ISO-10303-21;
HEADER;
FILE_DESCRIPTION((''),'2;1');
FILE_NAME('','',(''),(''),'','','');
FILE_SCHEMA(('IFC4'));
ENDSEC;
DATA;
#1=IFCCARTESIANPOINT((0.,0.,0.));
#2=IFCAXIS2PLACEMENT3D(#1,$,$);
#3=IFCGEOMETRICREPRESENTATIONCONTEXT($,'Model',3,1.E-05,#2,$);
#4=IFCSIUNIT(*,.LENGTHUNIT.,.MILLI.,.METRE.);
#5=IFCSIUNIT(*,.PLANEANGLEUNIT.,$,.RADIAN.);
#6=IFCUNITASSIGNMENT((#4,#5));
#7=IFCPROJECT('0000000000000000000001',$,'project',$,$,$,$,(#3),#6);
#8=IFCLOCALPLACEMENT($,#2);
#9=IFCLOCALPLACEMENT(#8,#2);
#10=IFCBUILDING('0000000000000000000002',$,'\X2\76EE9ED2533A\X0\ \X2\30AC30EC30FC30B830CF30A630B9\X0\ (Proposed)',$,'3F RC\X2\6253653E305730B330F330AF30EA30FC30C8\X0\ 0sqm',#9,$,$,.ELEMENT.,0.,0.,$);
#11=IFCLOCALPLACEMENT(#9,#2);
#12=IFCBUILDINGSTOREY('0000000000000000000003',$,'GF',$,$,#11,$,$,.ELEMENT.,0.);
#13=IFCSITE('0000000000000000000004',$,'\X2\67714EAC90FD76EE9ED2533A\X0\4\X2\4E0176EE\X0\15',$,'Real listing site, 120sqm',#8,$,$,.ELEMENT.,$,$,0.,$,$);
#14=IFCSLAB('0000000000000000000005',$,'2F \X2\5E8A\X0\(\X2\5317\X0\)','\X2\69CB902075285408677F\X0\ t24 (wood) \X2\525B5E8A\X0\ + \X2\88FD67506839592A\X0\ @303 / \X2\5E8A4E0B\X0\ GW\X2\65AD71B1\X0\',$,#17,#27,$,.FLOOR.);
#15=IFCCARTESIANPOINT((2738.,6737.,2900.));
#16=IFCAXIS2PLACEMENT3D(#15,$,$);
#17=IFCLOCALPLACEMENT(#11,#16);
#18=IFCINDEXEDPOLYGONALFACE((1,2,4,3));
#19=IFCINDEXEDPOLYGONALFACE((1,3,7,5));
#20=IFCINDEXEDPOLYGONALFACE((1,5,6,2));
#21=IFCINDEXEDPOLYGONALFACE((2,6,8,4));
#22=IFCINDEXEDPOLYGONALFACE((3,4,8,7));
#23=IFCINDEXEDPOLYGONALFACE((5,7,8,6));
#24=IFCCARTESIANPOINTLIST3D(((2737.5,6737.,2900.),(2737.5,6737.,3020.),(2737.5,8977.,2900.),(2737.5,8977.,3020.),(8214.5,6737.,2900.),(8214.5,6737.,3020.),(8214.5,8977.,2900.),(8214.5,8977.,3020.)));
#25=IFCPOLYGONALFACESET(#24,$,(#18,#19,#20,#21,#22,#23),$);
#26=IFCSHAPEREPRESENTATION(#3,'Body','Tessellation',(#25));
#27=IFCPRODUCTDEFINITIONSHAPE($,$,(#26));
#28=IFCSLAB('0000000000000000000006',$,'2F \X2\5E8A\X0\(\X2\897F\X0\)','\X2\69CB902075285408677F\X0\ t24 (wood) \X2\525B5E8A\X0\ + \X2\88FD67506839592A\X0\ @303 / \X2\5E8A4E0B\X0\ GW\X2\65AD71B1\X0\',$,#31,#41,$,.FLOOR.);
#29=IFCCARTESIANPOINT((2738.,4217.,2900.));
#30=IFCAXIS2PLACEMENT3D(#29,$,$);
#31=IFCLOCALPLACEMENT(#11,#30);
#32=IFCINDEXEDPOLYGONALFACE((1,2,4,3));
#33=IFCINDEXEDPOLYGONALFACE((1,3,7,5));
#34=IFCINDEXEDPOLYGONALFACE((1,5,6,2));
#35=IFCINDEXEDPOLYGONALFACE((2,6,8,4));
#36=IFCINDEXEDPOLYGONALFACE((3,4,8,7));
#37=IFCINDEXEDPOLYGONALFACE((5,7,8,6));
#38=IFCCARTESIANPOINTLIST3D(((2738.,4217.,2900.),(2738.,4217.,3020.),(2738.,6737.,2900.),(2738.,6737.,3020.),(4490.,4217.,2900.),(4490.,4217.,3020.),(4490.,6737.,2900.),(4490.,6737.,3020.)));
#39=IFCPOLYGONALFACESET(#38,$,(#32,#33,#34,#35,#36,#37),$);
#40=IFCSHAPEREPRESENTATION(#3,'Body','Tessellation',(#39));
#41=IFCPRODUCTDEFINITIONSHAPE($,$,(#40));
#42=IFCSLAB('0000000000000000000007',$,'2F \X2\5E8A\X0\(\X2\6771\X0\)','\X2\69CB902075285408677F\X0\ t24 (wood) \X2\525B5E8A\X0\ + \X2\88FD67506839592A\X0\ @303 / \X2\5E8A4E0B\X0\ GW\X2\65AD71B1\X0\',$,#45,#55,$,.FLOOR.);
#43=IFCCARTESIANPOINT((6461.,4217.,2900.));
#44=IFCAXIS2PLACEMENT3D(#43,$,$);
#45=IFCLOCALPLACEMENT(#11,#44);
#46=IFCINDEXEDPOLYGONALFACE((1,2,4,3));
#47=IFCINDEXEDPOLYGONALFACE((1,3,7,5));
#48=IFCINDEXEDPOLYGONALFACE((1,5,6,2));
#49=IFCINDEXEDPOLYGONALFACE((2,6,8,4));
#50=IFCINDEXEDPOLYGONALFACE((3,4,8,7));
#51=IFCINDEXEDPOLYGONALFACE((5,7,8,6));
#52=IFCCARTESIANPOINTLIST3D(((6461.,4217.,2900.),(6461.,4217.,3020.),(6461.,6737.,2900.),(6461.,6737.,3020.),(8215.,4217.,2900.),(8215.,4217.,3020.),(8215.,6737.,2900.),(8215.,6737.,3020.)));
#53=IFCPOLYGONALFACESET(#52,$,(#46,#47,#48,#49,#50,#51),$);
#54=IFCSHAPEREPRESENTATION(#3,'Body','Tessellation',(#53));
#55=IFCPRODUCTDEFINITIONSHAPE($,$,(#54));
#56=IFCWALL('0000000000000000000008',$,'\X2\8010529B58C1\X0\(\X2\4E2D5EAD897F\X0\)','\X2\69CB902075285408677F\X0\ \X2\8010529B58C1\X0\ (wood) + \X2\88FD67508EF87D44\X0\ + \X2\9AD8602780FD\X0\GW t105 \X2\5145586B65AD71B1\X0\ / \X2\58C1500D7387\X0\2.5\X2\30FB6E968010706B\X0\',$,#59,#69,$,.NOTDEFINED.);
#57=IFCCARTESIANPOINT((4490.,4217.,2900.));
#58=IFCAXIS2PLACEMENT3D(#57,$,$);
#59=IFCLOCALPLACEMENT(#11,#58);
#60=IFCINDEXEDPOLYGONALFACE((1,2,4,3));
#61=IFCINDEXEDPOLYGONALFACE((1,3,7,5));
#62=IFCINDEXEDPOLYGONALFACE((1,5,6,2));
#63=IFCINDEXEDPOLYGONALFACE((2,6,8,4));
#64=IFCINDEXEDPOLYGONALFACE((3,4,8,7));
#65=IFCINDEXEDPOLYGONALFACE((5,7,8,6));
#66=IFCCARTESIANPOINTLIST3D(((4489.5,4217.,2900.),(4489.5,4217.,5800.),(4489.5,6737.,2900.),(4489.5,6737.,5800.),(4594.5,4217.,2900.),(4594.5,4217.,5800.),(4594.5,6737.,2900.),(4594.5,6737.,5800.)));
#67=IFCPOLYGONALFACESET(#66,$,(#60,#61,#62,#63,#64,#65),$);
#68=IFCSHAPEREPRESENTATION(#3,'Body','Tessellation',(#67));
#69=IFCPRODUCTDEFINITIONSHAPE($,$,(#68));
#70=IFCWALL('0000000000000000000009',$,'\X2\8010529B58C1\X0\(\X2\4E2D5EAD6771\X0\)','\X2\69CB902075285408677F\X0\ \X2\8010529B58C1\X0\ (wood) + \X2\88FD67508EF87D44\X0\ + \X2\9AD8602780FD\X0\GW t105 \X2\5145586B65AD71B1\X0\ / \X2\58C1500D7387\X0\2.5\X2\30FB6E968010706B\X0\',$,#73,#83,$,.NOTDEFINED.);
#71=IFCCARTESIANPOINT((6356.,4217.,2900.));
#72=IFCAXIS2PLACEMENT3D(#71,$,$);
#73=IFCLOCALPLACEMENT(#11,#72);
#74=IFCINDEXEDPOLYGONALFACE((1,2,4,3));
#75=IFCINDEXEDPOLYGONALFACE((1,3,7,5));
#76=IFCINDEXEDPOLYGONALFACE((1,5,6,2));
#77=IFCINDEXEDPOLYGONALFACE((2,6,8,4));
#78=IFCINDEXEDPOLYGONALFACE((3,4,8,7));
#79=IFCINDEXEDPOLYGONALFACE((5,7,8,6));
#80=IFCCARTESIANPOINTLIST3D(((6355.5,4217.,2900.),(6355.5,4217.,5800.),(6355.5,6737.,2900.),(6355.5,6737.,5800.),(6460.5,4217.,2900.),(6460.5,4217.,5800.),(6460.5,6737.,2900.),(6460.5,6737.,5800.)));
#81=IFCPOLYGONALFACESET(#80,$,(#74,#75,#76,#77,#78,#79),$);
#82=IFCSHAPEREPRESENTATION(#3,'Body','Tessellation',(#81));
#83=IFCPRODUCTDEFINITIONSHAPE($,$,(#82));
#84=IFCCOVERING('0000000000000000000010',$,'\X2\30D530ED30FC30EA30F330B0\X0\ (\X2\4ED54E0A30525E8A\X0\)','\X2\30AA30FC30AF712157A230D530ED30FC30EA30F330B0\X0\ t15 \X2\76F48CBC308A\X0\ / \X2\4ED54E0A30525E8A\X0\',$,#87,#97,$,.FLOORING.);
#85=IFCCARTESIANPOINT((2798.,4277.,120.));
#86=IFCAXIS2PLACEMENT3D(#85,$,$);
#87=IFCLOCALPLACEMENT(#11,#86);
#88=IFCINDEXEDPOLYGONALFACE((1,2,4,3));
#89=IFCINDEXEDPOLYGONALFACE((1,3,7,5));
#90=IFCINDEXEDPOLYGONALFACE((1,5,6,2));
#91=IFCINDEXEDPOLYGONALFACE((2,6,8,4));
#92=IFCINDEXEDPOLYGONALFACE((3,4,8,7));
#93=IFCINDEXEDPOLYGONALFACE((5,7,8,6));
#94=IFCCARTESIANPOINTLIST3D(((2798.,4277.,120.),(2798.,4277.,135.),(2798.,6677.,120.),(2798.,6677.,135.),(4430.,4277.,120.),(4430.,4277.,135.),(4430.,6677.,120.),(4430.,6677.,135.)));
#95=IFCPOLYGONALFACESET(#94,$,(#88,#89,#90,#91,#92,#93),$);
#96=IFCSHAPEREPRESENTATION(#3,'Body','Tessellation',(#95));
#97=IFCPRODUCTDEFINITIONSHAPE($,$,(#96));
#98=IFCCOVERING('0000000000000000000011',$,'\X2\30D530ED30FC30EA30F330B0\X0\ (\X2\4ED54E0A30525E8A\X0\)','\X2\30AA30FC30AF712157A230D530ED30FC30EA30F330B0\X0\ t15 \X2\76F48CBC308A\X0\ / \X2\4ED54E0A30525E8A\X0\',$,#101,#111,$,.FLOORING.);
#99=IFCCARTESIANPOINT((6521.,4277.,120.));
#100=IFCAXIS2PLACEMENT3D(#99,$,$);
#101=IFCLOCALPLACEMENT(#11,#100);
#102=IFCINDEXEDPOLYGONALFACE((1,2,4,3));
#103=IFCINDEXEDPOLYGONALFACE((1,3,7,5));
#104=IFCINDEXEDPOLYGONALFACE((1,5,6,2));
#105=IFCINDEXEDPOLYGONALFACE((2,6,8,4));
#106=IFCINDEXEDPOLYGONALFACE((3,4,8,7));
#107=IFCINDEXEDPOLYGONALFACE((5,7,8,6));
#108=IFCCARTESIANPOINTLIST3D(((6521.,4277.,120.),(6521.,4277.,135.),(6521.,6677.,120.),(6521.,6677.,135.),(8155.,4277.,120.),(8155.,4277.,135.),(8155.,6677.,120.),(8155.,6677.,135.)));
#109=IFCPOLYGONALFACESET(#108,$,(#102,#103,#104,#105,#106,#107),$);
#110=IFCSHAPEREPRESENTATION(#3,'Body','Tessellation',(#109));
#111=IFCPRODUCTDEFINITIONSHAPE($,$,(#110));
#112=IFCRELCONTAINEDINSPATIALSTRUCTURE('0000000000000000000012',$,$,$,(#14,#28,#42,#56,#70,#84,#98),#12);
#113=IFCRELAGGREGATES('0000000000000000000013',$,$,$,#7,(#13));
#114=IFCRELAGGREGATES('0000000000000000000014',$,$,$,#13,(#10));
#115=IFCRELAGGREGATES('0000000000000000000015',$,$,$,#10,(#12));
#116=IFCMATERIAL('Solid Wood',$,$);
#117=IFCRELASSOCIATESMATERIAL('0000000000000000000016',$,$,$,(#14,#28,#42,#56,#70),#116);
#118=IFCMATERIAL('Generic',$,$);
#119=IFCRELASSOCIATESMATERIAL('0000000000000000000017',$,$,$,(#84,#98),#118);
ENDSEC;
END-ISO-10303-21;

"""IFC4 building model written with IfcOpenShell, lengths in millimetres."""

from ifc_helpers import new_model, si_unit, frame, frame_2d, origin, place, context, project, spatial, rectangle, extrude, material, element, save


model = new_model("IFC4")

# Units and contexts
model_context = context("Model", 3, precision=1e-05, world=origin())
ifc_project = project(units=[si_unit("LENGTHUNIT", "METRE", prefix="MILLI"), si_unit("PLANEANGLEUNIT", "RADIAN")], contexts=[model_context])

# Site, building, storey
site_placement = place(None, origin())
site = spatial("IfcSite", under=ifc_project, at=site_placement, Name="東京都目黒区4丁目15", ObjectType="Real listing site, 120sqm", CompositionType="ELEMENT", RefElevation=0.0)
building_placement = place(site_placement, origin())
building = spatial("IfcBuilding", under=site, at=building_placement, Name="目黒区 ガレージハウス (Proposed)", ObjectType="3F RC打放しコンクリート 0sqm", CompositionType="ELEMENT", ElevationOfRefHeight=0.0, ElevationOfTerrain=0.0)
storey_placement = place(building_placement, origin())
storey = spatial("IfcBuildingStorey", under=building, at=storey_placement, Name="GF", CompositionType="ELEMENT", Elevation=0.0)

# Slabs
ifc_material_1 = material(Name="Solid Wood")
slab_1_placement = place(storey_placement, frame((2738.0, 6737.0, 2900.0)))
element("IfcSlab", 1, at=slab_1_placement, inside=storey, material=ifc_material_1, Name="2F 床(北)", Description="構造用合板 t24 (wood) 剛床 + 製材根太 @303 / 床下 GW断熱", PredefinedType="FLOOR", context=model_context, shape_type="SweptSolid", body=[
    extrude(rectangle(XDim=5477.0, YDim=2240.0, at=frame_2d((2738.0, 1120.0))), frame((2738.0, 6737.0, 2900.0)), (0.0, 0.0, 1.0), 120.0),
])
slab_2_placement = place(storey_placement, frame((2738.0, 4217.0, 2900.0)))
element("IfcSlab", 2, at=slab_2_placement, inside=storey, material=ifc_material_1, Name="2F 床(西)", Description="構造用合板 t24 (wood) 剛床 + 製材根太 @303 / 床下 GW断熱", PredefinedType="FLOOR", context=model_context, shape_type="SweptSolid", body=[
    extrude(rectangle(XDim=1752.0, YDim=2520.0, at=frame_2d((876.0, 1260.0))), frame((2738.0, 4217.0, 2900.0)), (0.0, 0.0, 1.0), 120.0),
])
slab_3_placement = place(storey_placement, frame((6461.0, 4217.0, 2900.0)))
element("IfcSlab", 3, at=slab_3_placement, inside=storey, material=ifc_material_1, Name="2F 床(東)", Description="構造用合板 t24 (wood) 剛床 + 製材根太 @303 / 床下 GW断熱", PredefinedType="FLOOR", context=model_context, shape_type="SweptSolid", body=[
    extrude(rectangle(XDim=1754.0, YDim=2520.0, at=frame_2d((877.0, 1260.0))), frame((6461.0, 4217.0, 2900.0)), (0.0, 0.0, 1.0), 120.0),
])

# Walls
wall_1_placement = place(storey_placement, frame((4490.0, 4217.0, 2900.0)))
element("IfcWall", 4, at=wall_1_placement, inside=storey, material=ifc_material_1, Name="耐力壁(中庭西)", Description="構造用合板 耐力壁 (wood) + 製材軸組 + 高性能GW t105 充填断熱 / 壁倍率2.5・準耐火", PredefinedType="NOTDEFINED", context=model_context, shape_type="SweptSolid", body=[
    extrude(rectangle(XDim=105.0, YDim=2520.0, at=frame_2d((52.0, 1260.0))), frame((4490.0, 4217.0, 2900.0)), (0.0, 0.0, 1.0), 2900.0),
])
wall_2_placement = place(storey_placement, frame((6356.0, 4217.0, 2900.0)))
element("IfcWall", 5, at=wall_2_placement, inside=storey, material=ifc_material_1, Name="耐力壁(中庭東)", Description="構造用合板 耐力壁 (wood) + 製材軸組 + 高性能GW t105 充填断熱 / 壁倍率2.5・準耐火", PredefinedType="NOTDEFINED", context=model_context, shape_type="SweptSolid", body=[
    extrude(rectangle(XDim=105.0, YDim=2520.0, at=frame_2d((52.0, 1260.0))), frame((6356.0, 4217.0, 2900.0)), (0.0, 0.0, 1.0), 2900.0),
])

# Coverings
ifc_material_2 = material(Name="Generic")
covering_1_placement = place(storey_placement, frame((2798.0, 4277.0, 120.0)))
element("IfcCovering", 6, at=covering_1_placement, inside=storey, material=ifc_material_2, Name="フローリング (仕上げ床)", Description="オーク無垢フローリング t15 直貼り / 仕上げ床", PredefinedType="FLOORING", context=model_context, shape_type="SweptSolid", body=[
    extrude(rectangle(XDim=1632.0, YDim=2400.0, at=frame_2d((816.0, 1200.0))), frame((2798.0, 4277.0, 120.0)), (0.0, 0.0, 1.0), 15.0),
])
covering_2_placement = place(storey_placement, frame((6521.0, 4277.0, 120.0)))
element("IfcCovering", 7, at=covering_2_placement, inside=storey, material=ifc_material_2, Name="フローリング (仕上げ床)", Description="オーク無垢フローリング t15 直貼り / 仕上げ床", PredefinedType="FLOORING", context=model_context, shape_type="SweptSolid", body=[
    extrude(rectangle(XDim=1634.0, YDim=2400.0, at=frame_2d((817.0, 1200.0))), frame((6521.0, 4277.0, 120.0)), (0.0, 0.0, 1.0), 15.0),
])

save(model, "model.ifc")
